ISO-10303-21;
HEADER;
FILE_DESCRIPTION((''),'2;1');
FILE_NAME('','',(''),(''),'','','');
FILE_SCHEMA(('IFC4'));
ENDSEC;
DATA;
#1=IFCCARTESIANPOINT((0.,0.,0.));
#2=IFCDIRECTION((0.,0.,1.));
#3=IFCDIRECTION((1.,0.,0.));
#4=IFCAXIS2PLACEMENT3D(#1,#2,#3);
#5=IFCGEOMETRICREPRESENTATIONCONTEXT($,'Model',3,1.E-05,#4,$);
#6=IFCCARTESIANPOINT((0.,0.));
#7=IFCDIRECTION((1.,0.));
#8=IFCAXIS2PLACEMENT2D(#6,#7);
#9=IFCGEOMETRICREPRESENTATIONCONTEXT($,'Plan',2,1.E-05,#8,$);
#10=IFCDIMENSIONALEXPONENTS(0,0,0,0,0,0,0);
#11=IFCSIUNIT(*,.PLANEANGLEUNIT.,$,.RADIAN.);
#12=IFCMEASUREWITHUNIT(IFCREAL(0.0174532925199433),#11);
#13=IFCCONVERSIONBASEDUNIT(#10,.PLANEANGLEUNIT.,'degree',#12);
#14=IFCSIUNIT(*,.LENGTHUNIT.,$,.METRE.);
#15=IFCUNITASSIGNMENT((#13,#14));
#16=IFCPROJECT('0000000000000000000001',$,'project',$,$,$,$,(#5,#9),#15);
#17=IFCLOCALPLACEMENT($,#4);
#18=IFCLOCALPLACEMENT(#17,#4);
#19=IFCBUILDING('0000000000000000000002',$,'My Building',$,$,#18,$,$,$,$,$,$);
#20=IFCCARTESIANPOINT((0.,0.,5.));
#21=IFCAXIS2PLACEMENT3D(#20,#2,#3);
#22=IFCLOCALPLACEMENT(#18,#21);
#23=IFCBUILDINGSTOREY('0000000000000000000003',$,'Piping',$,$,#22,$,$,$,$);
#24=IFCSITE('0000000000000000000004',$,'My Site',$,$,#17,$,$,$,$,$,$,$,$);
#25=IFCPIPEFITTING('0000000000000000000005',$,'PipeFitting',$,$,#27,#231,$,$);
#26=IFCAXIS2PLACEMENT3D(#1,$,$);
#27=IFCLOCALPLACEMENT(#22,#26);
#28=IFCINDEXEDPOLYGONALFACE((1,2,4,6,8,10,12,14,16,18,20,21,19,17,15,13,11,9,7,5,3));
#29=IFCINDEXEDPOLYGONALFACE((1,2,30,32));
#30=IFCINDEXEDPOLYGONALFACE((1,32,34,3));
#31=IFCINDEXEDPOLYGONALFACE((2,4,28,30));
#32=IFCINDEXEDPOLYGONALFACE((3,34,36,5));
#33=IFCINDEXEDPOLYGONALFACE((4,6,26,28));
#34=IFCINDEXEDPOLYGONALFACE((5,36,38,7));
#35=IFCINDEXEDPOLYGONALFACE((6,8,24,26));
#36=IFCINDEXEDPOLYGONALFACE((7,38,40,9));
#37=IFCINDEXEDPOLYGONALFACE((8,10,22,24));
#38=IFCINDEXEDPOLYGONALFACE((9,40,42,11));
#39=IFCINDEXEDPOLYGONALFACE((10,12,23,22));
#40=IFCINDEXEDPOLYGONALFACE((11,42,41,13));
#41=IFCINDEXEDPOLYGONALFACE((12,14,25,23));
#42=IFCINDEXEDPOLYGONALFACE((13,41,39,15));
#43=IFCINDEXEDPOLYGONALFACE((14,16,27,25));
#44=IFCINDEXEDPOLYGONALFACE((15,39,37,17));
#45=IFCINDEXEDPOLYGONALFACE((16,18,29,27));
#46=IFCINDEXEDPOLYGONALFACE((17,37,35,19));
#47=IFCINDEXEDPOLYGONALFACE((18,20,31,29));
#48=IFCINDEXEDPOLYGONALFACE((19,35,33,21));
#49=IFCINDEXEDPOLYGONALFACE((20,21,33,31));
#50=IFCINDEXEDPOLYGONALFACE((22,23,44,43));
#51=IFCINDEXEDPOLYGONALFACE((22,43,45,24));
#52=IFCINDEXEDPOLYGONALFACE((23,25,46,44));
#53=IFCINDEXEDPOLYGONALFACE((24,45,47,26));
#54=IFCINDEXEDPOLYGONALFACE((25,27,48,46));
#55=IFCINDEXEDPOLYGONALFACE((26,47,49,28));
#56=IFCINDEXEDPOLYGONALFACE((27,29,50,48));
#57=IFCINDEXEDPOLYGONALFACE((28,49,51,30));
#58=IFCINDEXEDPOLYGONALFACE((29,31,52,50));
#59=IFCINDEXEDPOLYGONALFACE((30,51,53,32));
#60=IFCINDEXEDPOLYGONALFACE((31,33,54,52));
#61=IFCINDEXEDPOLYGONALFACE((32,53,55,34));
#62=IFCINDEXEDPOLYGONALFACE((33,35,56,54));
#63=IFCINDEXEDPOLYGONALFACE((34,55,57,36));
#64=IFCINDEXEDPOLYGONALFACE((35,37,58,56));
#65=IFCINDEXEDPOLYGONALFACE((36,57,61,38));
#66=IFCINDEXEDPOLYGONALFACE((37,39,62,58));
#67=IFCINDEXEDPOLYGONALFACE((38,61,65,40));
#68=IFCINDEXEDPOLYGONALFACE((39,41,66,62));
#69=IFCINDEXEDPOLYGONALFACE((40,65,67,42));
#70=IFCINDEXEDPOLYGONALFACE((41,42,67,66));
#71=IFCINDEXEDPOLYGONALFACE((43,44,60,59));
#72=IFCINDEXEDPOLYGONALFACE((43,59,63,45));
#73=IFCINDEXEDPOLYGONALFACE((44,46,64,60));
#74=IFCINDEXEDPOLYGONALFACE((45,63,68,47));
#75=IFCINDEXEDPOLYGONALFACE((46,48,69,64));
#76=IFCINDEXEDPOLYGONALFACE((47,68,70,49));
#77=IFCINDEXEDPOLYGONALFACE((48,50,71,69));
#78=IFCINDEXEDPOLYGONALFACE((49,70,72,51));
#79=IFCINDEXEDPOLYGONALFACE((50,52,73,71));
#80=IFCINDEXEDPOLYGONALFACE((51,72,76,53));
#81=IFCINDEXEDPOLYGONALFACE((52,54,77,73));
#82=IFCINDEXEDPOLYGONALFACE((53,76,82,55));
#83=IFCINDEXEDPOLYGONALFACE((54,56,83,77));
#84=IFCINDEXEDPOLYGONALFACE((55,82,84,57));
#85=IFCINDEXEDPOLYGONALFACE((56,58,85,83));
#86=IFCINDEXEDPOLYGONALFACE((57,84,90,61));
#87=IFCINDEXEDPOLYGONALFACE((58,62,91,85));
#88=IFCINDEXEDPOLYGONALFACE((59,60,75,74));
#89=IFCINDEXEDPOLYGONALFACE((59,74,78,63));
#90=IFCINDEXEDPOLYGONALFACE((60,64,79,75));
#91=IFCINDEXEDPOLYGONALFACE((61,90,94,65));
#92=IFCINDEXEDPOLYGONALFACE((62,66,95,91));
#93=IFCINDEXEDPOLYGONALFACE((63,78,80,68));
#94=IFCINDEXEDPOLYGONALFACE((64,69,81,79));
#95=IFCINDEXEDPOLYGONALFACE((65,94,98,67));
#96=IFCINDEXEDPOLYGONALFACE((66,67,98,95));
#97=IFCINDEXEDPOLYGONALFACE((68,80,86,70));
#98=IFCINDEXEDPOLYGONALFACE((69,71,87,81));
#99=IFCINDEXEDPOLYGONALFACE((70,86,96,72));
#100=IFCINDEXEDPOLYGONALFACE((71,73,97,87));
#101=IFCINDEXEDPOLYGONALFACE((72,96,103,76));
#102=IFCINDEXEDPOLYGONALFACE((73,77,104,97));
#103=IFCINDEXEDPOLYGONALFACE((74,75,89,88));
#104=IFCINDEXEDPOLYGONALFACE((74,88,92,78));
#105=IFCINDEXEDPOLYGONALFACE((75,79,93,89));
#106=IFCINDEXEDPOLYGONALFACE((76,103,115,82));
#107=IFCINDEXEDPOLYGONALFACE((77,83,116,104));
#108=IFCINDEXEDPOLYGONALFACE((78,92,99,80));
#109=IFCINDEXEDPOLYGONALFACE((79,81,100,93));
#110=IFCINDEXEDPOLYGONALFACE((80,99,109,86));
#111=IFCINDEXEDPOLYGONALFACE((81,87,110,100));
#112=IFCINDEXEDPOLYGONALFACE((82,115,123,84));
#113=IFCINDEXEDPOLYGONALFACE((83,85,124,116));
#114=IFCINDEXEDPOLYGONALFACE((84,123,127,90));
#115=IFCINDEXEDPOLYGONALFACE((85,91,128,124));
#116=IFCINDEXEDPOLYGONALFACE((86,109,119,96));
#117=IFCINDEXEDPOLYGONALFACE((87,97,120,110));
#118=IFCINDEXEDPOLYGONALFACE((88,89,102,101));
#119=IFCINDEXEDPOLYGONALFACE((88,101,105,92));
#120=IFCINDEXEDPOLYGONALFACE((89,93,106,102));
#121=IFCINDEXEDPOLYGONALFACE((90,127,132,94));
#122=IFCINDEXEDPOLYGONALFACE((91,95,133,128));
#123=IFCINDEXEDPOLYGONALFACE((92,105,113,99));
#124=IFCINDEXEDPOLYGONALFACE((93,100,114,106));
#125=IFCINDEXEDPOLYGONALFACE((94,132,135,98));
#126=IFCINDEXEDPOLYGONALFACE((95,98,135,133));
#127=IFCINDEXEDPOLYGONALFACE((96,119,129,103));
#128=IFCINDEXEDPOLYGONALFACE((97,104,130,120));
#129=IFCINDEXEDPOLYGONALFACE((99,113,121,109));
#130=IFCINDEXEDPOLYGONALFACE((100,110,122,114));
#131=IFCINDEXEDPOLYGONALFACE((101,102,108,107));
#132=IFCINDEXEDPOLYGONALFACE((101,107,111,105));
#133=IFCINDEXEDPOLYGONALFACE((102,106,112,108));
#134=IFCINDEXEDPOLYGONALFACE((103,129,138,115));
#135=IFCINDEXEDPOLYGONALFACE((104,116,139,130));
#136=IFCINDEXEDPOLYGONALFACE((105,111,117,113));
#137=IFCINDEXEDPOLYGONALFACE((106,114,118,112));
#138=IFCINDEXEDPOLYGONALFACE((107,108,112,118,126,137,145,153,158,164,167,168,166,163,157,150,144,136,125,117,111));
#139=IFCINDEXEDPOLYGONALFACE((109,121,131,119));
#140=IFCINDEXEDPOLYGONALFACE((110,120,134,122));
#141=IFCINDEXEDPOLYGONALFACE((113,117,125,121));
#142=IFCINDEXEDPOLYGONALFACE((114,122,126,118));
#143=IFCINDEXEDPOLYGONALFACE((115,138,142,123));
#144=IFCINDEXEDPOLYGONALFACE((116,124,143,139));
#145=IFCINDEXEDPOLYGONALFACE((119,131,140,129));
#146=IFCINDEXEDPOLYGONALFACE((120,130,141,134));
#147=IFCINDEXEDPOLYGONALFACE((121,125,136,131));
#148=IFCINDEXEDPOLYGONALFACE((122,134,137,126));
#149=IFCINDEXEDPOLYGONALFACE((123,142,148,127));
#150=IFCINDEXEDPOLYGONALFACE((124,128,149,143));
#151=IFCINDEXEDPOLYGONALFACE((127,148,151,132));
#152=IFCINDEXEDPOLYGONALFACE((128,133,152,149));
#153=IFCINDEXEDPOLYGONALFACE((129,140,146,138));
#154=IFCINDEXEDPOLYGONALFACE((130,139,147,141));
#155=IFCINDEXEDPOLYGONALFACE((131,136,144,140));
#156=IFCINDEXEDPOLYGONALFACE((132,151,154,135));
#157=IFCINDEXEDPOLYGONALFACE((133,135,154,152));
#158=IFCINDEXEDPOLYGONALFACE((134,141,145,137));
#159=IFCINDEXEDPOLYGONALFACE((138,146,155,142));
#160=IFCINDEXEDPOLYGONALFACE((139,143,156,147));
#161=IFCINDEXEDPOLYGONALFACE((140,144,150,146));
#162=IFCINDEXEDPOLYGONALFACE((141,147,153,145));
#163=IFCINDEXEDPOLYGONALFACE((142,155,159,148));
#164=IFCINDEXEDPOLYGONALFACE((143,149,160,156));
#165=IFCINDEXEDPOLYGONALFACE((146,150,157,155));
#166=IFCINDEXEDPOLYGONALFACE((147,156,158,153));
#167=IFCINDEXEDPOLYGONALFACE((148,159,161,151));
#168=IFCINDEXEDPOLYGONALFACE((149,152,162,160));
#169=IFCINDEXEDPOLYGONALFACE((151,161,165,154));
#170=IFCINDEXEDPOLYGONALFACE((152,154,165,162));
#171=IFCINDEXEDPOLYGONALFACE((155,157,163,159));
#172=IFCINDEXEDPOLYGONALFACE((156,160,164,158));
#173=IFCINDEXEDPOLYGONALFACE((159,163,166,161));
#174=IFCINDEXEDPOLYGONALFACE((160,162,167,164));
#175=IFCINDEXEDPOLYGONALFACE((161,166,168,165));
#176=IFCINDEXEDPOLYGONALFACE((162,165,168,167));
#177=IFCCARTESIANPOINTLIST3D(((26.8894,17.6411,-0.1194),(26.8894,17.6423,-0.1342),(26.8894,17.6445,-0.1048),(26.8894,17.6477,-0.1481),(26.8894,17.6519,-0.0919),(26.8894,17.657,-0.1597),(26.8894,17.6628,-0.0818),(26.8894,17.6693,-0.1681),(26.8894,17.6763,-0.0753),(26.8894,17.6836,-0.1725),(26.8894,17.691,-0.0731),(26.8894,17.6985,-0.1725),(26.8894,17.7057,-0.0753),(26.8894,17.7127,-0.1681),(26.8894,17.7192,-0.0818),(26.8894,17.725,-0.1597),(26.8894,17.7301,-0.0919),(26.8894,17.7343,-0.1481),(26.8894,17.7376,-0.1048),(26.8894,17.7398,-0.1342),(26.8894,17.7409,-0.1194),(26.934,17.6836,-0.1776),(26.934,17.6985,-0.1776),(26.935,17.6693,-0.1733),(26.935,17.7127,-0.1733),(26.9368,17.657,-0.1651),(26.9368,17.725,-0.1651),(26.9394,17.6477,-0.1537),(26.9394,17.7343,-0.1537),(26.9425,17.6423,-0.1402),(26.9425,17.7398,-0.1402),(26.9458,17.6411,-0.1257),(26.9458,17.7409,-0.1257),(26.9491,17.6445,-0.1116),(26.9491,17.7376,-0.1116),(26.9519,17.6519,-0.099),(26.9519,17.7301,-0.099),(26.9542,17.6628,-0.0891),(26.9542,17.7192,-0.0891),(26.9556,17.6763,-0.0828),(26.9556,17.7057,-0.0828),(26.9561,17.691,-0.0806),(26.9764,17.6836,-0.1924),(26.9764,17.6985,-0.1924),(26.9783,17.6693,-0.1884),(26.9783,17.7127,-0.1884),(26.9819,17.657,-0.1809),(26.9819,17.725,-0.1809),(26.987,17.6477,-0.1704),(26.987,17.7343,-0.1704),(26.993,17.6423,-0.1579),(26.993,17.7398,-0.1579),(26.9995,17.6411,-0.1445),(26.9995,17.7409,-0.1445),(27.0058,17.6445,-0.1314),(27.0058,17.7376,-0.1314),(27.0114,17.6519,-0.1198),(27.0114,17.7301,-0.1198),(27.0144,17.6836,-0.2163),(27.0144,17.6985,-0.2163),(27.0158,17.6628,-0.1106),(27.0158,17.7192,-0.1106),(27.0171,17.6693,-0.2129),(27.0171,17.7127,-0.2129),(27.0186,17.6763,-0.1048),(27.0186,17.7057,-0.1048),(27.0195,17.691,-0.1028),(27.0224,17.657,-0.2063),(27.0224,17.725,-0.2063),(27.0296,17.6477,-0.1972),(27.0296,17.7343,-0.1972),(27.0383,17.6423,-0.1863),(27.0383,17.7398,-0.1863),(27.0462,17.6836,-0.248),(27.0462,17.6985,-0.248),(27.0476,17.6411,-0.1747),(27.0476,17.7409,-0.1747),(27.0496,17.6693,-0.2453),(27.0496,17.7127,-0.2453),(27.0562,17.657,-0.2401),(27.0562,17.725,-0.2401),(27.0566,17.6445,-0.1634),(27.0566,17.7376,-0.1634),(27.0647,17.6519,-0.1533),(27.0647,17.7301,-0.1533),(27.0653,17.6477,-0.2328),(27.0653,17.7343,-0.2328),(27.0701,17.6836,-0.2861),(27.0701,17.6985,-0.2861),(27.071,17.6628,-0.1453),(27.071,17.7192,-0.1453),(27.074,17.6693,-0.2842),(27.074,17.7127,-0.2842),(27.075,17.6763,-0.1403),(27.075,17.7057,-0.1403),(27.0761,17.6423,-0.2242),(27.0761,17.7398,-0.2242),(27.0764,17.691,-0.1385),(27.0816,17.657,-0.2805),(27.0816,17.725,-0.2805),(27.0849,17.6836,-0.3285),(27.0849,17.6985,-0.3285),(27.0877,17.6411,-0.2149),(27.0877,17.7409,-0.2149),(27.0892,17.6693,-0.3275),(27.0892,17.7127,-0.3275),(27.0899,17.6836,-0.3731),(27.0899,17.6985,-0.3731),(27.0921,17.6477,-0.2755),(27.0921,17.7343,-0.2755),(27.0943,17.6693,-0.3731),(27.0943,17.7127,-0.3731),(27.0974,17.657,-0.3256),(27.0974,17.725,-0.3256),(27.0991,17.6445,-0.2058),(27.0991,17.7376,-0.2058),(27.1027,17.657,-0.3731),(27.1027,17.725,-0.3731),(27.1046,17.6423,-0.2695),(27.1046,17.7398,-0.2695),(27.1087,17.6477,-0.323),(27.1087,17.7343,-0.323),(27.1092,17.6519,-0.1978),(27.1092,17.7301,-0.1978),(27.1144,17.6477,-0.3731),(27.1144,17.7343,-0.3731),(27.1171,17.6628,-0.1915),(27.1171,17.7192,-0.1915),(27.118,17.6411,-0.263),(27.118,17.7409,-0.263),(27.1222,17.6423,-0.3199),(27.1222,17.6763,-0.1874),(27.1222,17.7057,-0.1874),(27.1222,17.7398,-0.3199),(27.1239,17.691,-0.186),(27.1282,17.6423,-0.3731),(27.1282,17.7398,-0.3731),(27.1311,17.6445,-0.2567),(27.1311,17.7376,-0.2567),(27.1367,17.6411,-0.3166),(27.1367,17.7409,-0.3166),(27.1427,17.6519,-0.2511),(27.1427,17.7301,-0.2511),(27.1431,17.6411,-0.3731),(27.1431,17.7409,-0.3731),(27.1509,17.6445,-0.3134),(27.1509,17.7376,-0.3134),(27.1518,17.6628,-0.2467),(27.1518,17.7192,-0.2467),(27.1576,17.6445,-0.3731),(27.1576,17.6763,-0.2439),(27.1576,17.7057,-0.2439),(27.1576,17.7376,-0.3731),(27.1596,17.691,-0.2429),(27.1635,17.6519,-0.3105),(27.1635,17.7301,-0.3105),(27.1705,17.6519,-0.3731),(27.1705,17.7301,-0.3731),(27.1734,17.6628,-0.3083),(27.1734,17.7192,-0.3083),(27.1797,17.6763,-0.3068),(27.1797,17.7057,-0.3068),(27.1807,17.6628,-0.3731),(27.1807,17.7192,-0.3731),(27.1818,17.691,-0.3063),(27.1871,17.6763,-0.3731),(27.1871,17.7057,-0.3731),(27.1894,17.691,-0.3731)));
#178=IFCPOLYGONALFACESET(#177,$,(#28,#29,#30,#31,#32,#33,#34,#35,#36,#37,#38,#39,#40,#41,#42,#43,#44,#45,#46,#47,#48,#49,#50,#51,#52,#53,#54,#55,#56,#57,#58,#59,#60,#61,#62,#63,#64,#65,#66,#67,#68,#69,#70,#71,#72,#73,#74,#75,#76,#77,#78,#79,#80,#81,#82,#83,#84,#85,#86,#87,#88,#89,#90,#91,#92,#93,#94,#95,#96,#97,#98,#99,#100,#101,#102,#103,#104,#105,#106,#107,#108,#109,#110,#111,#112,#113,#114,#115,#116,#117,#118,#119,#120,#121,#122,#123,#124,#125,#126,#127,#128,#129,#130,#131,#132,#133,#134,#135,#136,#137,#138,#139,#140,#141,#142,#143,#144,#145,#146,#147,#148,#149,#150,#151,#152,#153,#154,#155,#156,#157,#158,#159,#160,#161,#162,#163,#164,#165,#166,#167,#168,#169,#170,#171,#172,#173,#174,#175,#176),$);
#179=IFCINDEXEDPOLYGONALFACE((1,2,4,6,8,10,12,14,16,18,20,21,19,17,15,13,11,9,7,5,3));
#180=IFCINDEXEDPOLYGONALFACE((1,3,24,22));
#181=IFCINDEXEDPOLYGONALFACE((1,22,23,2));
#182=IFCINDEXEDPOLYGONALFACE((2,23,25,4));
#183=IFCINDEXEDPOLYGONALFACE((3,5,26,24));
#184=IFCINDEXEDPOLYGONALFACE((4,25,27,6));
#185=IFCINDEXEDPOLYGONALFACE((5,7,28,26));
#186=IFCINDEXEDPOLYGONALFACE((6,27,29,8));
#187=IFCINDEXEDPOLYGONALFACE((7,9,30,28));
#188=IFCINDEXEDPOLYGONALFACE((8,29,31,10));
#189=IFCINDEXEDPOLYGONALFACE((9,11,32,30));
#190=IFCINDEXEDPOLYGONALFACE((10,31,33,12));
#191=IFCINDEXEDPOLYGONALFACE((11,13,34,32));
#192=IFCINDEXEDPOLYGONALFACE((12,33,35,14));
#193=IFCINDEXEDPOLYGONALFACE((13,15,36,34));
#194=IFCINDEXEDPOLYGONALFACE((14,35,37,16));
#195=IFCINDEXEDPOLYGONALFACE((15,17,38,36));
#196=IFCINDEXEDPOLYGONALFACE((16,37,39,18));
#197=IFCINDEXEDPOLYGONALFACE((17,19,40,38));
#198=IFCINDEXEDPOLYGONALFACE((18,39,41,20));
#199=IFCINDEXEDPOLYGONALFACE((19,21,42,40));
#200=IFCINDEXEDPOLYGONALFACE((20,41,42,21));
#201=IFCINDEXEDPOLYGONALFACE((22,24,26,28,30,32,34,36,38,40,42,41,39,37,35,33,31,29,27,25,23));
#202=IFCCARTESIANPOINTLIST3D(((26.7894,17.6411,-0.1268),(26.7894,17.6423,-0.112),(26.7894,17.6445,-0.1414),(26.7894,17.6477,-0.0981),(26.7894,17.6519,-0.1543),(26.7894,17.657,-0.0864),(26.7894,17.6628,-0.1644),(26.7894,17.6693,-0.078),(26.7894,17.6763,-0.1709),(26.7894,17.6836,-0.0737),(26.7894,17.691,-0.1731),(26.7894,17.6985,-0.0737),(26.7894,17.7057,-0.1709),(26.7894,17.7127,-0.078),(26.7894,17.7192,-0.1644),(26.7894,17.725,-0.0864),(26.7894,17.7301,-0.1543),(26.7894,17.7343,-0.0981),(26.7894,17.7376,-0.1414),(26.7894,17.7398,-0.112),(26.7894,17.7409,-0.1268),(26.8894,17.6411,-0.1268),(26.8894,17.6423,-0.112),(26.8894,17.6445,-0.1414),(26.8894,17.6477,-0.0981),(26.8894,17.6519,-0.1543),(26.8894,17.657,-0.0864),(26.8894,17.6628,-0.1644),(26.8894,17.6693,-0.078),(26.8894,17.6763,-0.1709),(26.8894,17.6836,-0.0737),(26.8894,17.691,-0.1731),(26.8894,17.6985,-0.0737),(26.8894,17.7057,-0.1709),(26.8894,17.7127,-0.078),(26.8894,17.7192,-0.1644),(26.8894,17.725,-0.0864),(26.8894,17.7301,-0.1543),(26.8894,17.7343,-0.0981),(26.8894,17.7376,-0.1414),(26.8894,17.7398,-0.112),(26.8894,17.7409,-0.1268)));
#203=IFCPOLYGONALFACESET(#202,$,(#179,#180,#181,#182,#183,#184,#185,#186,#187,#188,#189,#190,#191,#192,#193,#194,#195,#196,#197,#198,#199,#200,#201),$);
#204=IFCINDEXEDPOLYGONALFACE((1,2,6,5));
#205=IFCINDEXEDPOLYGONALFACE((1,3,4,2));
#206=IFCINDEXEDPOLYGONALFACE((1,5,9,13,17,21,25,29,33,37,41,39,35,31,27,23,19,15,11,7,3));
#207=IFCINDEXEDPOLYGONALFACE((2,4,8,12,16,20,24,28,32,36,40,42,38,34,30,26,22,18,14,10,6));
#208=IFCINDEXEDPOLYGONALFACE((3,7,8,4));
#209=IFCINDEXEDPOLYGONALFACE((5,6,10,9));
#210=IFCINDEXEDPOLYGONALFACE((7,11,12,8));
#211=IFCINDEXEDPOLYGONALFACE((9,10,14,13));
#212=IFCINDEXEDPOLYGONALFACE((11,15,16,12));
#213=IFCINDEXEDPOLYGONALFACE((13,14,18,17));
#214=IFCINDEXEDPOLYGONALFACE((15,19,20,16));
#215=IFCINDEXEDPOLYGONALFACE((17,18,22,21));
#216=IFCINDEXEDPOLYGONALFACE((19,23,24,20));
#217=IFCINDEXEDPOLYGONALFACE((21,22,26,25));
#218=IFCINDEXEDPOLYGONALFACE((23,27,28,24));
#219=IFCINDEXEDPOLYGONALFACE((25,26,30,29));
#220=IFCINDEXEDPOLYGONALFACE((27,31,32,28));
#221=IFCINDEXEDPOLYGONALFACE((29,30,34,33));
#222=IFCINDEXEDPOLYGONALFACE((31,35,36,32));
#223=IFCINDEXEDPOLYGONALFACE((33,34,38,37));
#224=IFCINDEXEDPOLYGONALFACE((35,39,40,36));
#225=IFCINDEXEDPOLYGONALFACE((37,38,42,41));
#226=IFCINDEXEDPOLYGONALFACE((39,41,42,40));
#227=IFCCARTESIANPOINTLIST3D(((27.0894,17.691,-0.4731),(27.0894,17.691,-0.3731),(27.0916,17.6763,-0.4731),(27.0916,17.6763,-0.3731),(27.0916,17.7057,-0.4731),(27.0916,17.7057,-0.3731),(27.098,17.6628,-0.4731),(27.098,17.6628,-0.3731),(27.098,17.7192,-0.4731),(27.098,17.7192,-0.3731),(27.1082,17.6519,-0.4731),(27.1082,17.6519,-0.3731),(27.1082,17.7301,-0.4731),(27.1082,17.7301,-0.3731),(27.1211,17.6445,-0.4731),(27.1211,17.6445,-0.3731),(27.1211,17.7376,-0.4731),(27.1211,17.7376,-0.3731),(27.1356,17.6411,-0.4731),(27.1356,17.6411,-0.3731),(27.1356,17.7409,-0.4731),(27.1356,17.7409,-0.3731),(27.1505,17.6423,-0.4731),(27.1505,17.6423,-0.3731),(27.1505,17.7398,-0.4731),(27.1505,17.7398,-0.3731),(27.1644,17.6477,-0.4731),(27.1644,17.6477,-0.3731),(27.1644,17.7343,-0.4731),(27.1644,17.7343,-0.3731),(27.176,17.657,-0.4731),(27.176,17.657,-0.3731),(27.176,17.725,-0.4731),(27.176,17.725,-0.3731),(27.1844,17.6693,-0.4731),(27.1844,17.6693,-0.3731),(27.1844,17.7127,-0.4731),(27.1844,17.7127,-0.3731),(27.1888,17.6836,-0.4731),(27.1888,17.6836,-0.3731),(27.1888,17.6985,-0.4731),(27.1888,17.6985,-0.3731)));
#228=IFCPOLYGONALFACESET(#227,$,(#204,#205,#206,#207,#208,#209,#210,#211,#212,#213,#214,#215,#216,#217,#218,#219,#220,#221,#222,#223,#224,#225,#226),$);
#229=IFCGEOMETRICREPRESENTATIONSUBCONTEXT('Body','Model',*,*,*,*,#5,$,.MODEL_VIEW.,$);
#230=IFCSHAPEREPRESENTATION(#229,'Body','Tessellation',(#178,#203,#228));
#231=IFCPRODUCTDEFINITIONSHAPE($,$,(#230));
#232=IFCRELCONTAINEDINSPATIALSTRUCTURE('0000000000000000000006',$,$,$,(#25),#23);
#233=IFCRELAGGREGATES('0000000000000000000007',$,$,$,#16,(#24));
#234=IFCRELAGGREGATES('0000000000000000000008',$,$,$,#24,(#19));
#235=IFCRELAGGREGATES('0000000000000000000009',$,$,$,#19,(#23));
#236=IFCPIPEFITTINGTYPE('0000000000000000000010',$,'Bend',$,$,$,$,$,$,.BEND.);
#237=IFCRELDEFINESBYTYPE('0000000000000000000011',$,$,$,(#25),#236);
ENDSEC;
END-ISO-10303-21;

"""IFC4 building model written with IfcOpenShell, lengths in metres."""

from ifc_helpers import new_model, entity, si_unit, converted_unit, frame, origin_with_axes, origin_2d_with_axis, place, context, subcontext, project, spatial, circle, extrude, source, transform, mapped, type_object, type_shapes, element, save


model = new_model("IFC4")

# Units and contexts
model_context = context("Model", 3, precision=1e-05, world=origin_with_axes())
plan_context = context("Plan", 2, precision=1e-05, world=origin_2d_with_axis())
body_context = subcontext(model_context, "Body", "Model", "MODEL_VIEW")
ifc_project = project(units=[converted_unit("PLANEANGLEUNIT", "degree", entity("IfcReal", 0.0174532925199433), si_unit("PLANEANGLEUNIT", "RADIAN"), dimensions=[0, 0, 0, 0, 0, 0, 0]), si_unit("LENGTHUNIT", "METRE")], contexts=[model_context, plan_context])

# Site, building, storey
site_placement = place(None, origin_with_axes())
site = spatial("IfcSite", under=ifc_project, at=site_placement, Name="My Site")
building_placement = place(site_placement, origin_with_axes())
building = spatial("IfcBuilding", under=site, at=building_placement, Name="My Building")
storey_placement = place(building_placement, frame((0.0, 0.0, 5.0), z_axis=(0.0, 0.0, 1.0), x_axis=(1.0, 0.0, 0.0)))
storey = spatial("IfcBuildingStorey", under=building, at=storey_placement, Name="Piping")

# Pipe fitting
pipe_fitting_type_1 = type_object("IfcPipeFittingType", Name="Bend", PredefinedType="BEND")
shared_shape = source(origin_with_axes(), body_context, "Body", "SolidModel", [
    entity("IfcSweptDiskSolid", entity("IfcIndexedPolyCurve", entity("IfcCartesianPointList3D", [[0.0, 0.0, -0.1], [0.0732, 0.0, -0.2768], [0.25, 0.0, -0.35]]), [entity("IfcArcIndex", [1, 2, 3])]), 0.05),
    extrude(circle(Radius=0.05), origin_with_axes(), (0.0, 0.0, -1.0), 0.1),
    extrude(circle(Radius=0.05), frame((0.25, 0.0, -0.35), z_axis=(1.0, 0.0, 0.0), x_axis=(0.0, 0.0, 1.0)), (0.0, 0.0, 1.0), 0.1),
])
type_shapes(pipe_fitting_type_1, [shared_shape])
for number, where, z_axis, x_axis, name in (
    (1, (26.7894, 17.691, -0.1231), (-1.0, -0.000001, 0.0), (0.0, 0.0, -1.0), "PipeFitting"),
):
    element("IfcPipeFitting", number, at=place(storey_placement, frame(where, z_axis=z_axis, x_axis=x_axis)), inside=storey, type_object=pipe_fitting_type_1, Name=name, context=body_context, shape_type="MappedRepresentation", body=[
        mapped(shared_shape, transform((0.0, 0.0, 0.0), x_axis=(1.0, 0.0, 0.0), y_axis=(0.0, 1.0, 0.0), z_axis=(0.0, 0.0, 1.0), scale=1.0)),
    ])

save(model, "model.ifc")
